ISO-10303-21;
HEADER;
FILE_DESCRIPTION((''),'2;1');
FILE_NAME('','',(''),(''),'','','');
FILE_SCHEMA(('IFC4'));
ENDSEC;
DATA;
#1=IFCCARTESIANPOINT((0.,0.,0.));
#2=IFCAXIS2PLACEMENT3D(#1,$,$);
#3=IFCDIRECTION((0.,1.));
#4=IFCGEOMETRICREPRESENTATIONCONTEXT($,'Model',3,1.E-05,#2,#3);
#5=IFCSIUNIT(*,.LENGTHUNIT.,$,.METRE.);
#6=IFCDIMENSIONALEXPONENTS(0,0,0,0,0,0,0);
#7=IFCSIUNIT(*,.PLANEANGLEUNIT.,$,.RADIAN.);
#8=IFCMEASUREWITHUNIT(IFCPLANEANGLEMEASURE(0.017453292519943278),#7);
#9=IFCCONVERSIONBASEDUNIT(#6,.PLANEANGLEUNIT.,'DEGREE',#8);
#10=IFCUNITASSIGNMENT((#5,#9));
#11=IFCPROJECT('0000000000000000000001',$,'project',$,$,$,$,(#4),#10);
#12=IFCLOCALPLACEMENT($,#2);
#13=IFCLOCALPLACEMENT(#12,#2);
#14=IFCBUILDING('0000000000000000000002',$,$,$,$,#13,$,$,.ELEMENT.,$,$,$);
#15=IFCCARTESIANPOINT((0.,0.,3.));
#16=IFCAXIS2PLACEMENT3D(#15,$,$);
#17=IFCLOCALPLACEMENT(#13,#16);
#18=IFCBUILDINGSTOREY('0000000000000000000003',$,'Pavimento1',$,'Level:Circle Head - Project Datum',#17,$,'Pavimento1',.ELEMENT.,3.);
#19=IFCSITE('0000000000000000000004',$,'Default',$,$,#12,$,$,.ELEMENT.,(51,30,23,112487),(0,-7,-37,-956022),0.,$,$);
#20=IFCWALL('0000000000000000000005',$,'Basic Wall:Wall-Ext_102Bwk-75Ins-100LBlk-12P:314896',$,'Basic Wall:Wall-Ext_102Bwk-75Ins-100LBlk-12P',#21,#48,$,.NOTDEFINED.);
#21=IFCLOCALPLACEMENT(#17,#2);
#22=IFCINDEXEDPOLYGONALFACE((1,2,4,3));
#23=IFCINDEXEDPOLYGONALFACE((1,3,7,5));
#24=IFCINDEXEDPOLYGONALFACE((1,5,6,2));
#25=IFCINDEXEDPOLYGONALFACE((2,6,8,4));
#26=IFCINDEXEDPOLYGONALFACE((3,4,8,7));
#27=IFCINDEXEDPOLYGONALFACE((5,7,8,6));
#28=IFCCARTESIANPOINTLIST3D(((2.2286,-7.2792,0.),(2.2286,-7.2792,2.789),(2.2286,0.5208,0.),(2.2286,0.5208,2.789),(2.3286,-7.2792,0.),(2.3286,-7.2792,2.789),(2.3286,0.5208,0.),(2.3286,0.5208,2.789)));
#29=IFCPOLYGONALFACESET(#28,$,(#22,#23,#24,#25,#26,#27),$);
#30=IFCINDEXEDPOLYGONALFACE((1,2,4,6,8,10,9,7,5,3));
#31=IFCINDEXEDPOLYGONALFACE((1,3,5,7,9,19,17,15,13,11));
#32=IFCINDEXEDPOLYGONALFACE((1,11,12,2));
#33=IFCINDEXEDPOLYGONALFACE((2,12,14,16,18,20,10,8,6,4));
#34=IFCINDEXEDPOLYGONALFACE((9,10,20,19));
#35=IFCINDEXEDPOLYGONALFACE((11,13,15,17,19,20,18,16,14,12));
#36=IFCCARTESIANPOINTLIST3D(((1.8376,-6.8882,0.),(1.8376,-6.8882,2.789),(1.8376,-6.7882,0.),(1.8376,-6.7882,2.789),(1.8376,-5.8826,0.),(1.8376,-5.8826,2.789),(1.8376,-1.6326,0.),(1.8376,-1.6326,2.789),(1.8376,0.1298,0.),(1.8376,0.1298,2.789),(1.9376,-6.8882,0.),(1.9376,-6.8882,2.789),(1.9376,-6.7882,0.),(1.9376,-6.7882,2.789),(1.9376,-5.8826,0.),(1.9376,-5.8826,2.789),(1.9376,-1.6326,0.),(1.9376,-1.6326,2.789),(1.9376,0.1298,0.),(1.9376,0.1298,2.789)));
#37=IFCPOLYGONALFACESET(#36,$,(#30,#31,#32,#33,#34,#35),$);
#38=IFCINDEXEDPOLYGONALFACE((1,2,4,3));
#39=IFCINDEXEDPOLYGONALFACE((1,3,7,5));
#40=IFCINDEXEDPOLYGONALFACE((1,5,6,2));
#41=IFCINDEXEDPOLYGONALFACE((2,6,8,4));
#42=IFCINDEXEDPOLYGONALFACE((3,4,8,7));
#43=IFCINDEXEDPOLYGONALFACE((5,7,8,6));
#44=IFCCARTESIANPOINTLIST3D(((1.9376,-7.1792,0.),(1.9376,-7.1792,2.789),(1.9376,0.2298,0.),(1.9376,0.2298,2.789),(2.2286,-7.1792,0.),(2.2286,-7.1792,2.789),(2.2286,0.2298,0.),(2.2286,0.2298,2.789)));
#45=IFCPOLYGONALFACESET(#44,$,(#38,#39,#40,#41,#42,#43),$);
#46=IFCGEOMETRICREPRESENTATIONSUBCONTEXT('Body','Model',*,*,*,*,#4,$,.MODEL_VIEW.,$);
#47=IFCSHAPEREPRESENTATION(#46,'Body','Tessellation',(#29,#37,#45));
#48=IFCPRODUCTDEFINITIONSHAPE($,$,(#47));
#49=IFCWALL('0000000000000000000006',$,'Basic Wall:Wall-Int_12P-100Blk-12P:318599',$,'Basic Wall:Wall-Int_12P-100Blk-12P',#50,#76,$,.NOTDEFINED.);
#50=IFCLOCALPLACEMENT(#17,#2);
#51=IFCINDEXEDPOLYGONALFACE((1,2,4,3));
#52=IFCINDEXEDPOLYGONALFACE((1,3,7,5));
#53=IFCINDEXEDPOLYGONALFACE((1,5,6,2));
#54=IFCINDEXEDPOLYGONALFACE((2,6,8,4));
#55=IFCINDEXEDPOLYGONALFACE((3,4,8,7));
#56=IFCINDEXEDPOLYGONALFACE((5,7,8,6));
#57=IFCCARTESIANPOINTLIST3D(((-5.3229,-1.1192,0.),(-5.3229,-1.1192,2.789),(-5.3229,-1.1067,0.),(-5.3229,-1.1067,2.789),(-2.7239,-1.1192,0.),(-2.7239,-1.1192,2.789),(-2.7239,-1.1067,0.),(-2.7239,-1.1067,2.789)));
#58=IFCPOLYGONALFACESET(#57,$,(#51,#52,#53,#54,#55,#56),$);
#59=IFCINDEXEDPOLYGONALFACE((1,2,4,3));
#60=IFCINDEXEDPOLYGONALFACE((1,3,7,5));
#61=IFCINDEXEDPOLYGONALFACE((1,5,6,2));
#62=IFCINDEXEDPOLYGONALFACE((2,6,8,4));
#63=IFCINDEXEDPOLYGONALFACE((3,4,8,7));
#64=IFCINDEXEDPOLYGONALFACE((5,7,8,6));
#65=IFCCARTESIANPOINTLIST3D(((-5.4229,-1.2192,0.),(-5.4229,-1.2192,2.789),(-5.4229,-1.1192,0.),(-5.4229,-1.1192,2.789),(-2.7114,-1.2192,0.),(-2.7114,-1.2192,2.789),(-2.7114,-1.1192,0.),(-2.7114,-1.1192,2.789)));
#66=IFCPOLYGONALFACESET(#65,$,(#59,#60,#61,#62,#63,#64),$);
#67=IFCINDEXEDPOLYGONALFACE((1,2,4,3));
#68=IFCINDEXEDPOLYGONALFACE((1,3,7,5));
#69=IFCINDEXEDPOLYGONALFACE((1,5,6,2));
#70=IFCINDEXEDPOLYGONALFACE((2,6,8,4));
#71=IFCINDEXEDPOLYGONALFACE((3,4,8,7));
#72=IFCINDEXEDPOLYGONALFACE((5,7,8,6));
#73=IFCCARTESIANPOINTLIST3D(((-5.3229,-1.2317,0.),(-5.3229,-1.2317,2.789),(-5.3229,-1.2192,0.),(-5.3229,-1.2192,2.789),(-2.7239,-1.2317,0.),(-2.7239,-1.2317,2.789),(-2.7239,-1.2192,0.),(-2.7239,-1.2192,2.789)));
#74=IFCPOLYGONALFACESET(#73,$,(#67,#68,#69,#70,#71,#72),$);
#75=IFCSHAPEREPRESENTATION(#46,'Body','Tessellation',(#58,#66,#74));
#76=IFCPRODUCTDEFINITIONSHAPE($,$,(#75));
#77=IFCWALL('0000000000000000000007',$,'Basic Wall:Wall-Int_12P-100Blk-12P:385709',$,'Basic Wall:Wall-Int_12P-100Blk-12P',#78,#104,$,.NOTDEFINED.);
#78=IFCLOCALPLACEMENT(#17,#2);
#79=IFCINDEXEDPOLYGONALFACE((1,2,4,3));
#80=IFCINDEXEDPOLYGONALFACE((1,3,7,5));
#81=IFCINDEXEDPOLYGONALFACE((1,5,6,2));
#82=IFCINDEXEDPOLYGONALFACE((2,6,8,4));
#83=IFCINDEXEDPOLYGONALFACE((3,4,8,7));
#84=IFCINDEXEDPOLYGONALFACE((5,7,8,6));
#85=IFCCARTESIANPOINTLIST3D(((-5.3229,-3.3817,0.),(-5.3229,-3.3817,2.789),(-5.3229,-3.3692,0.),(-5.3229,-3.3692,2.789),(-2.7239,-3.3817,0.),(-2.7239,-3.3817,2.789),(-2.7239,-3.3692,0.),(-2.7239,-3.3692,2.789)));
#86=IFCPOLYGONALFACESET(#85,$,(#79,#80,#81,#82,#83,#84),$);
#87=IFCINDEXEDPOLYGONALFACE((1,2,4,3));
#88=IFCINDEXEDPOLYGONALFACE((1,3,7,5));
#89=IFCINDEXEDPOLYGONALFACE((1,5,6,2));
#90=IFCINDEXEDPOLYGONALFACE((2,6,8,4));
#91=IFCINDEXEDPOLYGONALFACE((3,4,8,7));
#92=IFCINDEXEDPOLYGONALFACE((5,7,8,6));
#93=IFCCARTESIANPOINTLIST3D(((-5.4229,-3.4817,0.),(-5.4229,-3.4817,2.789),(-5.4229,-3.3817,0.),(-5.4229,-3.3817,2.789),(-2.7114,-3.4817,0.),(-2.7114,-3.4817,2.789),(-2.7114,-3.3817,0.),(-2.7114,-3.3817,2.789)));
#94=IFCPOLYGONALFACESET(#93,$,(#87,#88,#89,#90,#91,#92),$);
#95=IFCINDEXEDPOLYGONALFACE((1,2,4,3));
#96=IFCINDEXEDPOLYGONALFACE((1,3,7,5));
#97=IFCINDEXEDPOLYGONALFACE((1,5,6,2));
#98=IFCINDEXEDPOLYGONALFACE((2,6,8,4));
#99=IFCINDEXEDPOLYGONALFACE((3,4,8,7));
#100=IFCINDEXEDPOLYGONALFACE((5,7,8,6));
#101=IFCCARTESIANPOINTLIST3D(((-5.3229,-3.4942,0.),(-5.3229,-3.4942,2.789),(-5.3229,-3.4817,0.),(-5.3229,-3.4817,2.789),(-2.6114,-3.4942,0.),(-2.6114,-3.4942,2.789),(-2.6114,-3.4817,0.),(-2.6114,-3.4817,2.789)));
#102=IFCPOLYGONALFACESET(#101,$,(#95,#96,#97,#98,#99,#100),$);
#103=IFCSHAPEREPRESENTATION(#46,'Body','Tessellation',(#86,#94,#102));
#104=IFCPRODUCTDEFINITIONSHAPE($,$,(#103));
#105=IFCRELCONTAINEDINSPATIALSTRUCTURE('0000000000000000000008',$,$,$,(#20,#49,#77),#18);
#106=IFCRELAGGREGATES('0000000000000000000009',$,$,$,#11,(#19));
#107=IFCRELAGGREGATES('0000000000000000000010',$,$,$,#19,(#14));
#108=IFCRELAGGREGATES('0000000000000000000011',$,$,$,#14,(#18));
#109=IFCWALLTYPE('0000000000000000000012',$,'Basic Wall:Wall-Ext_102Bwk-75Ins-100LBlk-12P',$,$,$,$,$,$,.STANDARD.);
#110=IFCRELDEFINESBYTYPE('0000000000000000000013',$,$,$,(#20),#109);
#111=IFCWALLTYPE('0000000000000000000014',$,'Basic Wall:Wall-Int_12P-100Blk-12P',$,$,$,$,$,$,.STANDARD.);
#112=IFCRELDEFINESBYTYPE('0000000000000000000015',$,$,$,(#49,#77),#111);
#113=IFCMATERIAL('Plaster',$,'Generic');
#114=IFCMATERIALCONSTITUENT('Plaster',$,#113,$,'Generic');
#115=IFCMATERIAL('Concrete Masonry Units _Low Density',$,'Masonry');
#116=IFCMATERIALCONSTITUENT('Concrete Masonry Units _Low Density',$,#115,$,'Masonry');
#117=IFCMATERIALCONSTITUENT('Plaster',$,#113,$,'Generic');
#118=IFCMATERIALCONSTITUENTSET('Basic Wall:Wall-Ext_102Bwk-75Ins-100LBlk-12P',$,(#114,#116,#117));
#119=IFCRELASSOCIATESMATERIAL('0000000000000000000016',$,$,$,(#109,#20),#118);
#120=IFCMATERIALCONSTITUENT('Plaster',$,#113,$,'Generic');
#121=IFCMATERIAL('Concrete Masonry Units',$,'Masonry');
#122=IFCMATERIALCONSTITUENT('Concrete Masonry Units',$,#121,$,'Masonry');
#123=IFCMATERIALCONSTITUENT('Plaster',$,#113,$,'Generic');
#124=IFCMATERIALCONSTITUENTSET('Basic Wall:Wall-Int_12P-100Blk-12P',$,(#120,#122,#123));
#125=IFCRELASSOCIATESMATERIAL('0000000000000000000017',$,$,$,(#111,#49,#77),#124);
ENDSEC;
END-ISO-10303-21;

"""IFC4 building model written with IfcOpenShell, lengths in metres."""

from ifc_helpers import new_model, entity, si_unit, converted_unit, direction, frame, origin, place, context, subcontext, project, spatial, indexed_curve, outline, extrude, material, constituent, constituent_set, type_object, element, save


model = new_model("IFC4")

# Units and contexts
model_context = context("Model", 3, precision=1e-05, world=origin(), true_north=direction((0.0, 1.0)))
body_context = subcontext(model_context, "Body", "Model", "MODEL_VIEW")
ifc_project = project(units=[si_unit("LENGTHUNIT", "METRE"), converted_unit("PLANEANGLEUNIT", "DEGREE", entity("IfcPlaneAngleMeasure", 0.017453292519943278), si_unit("PLANEANGLEUNIT", "RADIAN"), dimensions=[0, 0, 0, 0, 0, 0, 0])], contexts=[model_context])

# Site, building, storey
site_placement = place(None, origin())
site = spatial("IfcSite", under=ifc_project, at=site_placement, Name="Default", CompositionType="ELEMENT", RefLatitude=(51, 30, 23, 112487), RefLongitude=(0, -7, -37, -956022), RefElevation=0.0)
building_placement = place(site_placement, origin())
building = spatial("IfcBuilding", under=site, at=building_placement, CompositionType="ELEMENT")
storey_placement = place(building_placement, frame((0.0, 0.0, 3.0)))
storey = spatial("IfcBuildingStorey", under=building, at=storey_placement, Name="Pavimento1", ObjectType="Level:Circle Head - Project Datum", LongName="Pavimento1", CompositionType="ELEMENT", Elevation=3.0)

# Wall
ifc_material_1 = material(Name="Plaster", Category="Generic")
ifc_constituent_1 = constituent(ifc_material_1, Name="Plaster", Category="Generic")
ifc_material_2 = material(Name="Concrete Masonry Units _Low Density", Category="Masonry")
ifc_constituent_2 = constituent(ifc_material_2, Name="Concrete Masonry Units _Low Density", Category="Masonry")
ifc_constituent_3 = constituent(ifc_material_1, Name="Plaster", Category="Generic")
ifc_constituent_set_1 = constituent_set(constituents=[ifc_constituent_1, ifc_constituent_2, ifc_constituent_3], Name="Basic Wall:Wall-Ext_102Bwk-75Ins-100LBlk-12P")
wall_type_1 = type_object("IfcWallType", Name="Basic Wall:Wall-Ext_102Bwk-75Ins-100LBlk-12P", PredefinedType="STANDARD", material=ifc_constituent_set_1)
wall_1_placement = place(storey_placement, frame((2.0831, 0.1298, 0.0), z_axis=(0.0, 0.0, 1.0), x_axis=(0.0, -1.0, 0.0)))
element("IfcWall", 1, at=wall_1_placement, inside=storey, type_object=wall_type_1, material=ifc_constituent_set_1, Name="Basic Wall:Wall-Ext_102Bwk-75Ins-100LBlk-12P:314896", ObjectType="Basic Wall:Wall-Ext_102Bwk-75Ins-100LBlk-12P", PredefinedType="NOTDEFINED", context=body_context, shape_type="SweptSolid", body=[
    extrude(outline(indexed_curve([(-1.3945, -3.9), (1.3945, -3.9), (1.3945, 3.9), (-1.3945, 3.9), (-1.3945, -3.9)], self_intersect=False)), frame((3.509, 0.1455, 1.3945), z_axis=(0.0, 1.0, 0.0), x_axis=(0.0, 0.0, 1.0)), (0.0, 0.0, 1.0), 0.1),
    extrude(outline(indexed_curve([(-1.3945, -4.3422), (1.3945, -4.3422), (1.3945, -2.5797), (1.3945, 1.6703), (1.3945, 2.5758), (1.3945, 2.6758), (-1.3945, 2.6758), (-1.3945, 2.5758), (-1.3945, 1.6703), (-1.3945, -2.5797), (-1.3945, -4.3422)], self_intersect=False)), frame((4.3422, -0.2455, 1.3945), z_axis=(0.0, 1.0, 0.0), x_axis=(0.0, 0.0, 1.0)), (0.0, 0.0, 1.0), 0.1),
    extrude(outline(indexed_curve([(-1.3945, -3.7045), (1.3945, -3.7045), (1.3945, 3.7045), (-1.3945, 3.7045), (-1.3945, -3.7045)], self_intersect=False)), frame((3.6045, -0.1455, 1.3945), z_axis=(0.0, 1.0, 0.0), x_axis=(0.0, 0.0, 1.0)), (0.0, 0.0, 1.0), 0.291),
])

# Shared definitions
ifc_constituent_4 = constituent(ifc_material_1, Name="Plaster", Category="Generic")
ifc_material_3 = material(Name="Concrete Masonry Units", Category="Masonry")
ifc_constituent_5 = constituent(ifc_material_3, Name="Concrete Masonry Units", Category="Masonry")
ifc_constituent_6 = constituent(ifc_material_1, Name="Plaster", Category="Generic")
ifc_constituent_set_2 = constituent_set(constituents=[ifc_constituent_4, ifc_constituent_5, ifc_constituent_6], Name="Basic Wall:Wall-Int_12P-100Blk-12P")
wall_type_2 = type_object("IfcWallType", Name="Basic Wall:Wall-Int_12P-100Blk-12P", PredefinedType="STANDARD", material=ifc_constituent_set_2)

# Wall
wall_2_placement = place(storey_placement, frame((-2.7239, -1.1692, 0.0), z_axis=(0.0, 0.0, 1.0), x_axis=(-1.0, 0.0, 0.0)))
element("IfcWall", 2, at=wall_2_placement, inside=storey, type_object=wall_type_2, material=ifc_constituent_set_2, Name="Basic Wall:Wall-Int_12P-100Blk-12P:318599", ObjectType="Basic Wall:Wall-Int_12P-100Blk-12P", PredefinedType="NOTDEFINED", context=body_context, shape_type="SweptSolid", body=[
    extrude(outline(indexed_curve([(-0.0063, -1.2995), (0.0062, -1.2995), (0.0063, 1.2995), (-0.0062, 1.2995), (-0.0063, -1.2995)], self_intersect=False)), frame((1.2995, -0.0563, 0.0), z_axis=(0.0, 0.0, 1.0), x_axis=(0.0, 1.0, 0.0)), (0.0, 0.0, 1.0), 2.789),
    extrude(outline(indexed_curve([(-1.3558, -0.05), (1.3558, -0.05), (1.3558, 0.05), (-1.3558, 0.05), (-1.3558, -0.05)], self_intersect=False)), frame((1.3433, 0.0, 0.0)), (0.0, 0.0, 1.0), 2.789),
    extrude(outline(indexed_curve([(-0.0063, -1.2995), (0.0062, -1.2995), (0.0063, 1.2995), (-0.0062, 1.2995), (-0.0063, -1.2995)], self_intersect=False)), frame((1.2995, 0.0562, 0.0), z_axis=(0.0, 0.0, 1.0), x_axis=(0.0, -1.0, 0.0)), (0.0, 0.0, 1.0), 2.789),
])

# Wall
wall_3_placement = place(storey_placement, frame((-2.7239, -3.4317, 0.0), z_axis=(0.0, 0.0, 1.0), x_axis=(-1.0, 0.0, 0.0)))
element("IfcWall", 3, at=wall_3_placement, inside=storey, type_object=wall_type_2, material=ifc_constituent_set_2, Name="Basic Wall:Wall-Int_12P-100Blk-12P:385709", ObjectType="Basic Wall:Wall-Int_12P-100Blk-12P", PredefinedType="NOTDEFINED", context=body_context, shape_type="SweptSolid", body=[
    extrude(outline(indexed_curve([(-0.0063, -1.2995), (0.0062, -1.2995), (0.0063, 1.2995), (-0.0062, 1.2995), (-0.0063, -1.2995)], self_intersect=False)), frame((1.2995, -0.0563, 0.0), z_axis=(0.0, 0.0, 1.0), x_axis=(0.0, 1.0, 0.0)), (0.0, 0.0, 1.0), 2.789),
    extrude(outline(indexed_curve([(-1.3558, -0.05), (1.3558, -0.05), (1.3558, 0.05), (-1.3558, 0.05), (-1.3558, -0.05)], self_intersect=False)), frame((1.3433, 0.0, 0.0)), (0.0, 0.0, 1.0), 2.789),
    extrude(outline(indexed_curve([(-0.0063, -1.3558), (0.0062, -1.3558), (0.0063, 1.3558), (-0.0062, 1.3558), (-0.0063, -1.3558)], self_intersect=False)), frame((1.2433, 0.0563, 0.0), z_axis=(0.0, 0.0, 1.0), x_axis=(0.0, -1.0, 0.0)), (0.0, 0.0, 1.0), 2.789),
])

save(model, "model.ifc")
